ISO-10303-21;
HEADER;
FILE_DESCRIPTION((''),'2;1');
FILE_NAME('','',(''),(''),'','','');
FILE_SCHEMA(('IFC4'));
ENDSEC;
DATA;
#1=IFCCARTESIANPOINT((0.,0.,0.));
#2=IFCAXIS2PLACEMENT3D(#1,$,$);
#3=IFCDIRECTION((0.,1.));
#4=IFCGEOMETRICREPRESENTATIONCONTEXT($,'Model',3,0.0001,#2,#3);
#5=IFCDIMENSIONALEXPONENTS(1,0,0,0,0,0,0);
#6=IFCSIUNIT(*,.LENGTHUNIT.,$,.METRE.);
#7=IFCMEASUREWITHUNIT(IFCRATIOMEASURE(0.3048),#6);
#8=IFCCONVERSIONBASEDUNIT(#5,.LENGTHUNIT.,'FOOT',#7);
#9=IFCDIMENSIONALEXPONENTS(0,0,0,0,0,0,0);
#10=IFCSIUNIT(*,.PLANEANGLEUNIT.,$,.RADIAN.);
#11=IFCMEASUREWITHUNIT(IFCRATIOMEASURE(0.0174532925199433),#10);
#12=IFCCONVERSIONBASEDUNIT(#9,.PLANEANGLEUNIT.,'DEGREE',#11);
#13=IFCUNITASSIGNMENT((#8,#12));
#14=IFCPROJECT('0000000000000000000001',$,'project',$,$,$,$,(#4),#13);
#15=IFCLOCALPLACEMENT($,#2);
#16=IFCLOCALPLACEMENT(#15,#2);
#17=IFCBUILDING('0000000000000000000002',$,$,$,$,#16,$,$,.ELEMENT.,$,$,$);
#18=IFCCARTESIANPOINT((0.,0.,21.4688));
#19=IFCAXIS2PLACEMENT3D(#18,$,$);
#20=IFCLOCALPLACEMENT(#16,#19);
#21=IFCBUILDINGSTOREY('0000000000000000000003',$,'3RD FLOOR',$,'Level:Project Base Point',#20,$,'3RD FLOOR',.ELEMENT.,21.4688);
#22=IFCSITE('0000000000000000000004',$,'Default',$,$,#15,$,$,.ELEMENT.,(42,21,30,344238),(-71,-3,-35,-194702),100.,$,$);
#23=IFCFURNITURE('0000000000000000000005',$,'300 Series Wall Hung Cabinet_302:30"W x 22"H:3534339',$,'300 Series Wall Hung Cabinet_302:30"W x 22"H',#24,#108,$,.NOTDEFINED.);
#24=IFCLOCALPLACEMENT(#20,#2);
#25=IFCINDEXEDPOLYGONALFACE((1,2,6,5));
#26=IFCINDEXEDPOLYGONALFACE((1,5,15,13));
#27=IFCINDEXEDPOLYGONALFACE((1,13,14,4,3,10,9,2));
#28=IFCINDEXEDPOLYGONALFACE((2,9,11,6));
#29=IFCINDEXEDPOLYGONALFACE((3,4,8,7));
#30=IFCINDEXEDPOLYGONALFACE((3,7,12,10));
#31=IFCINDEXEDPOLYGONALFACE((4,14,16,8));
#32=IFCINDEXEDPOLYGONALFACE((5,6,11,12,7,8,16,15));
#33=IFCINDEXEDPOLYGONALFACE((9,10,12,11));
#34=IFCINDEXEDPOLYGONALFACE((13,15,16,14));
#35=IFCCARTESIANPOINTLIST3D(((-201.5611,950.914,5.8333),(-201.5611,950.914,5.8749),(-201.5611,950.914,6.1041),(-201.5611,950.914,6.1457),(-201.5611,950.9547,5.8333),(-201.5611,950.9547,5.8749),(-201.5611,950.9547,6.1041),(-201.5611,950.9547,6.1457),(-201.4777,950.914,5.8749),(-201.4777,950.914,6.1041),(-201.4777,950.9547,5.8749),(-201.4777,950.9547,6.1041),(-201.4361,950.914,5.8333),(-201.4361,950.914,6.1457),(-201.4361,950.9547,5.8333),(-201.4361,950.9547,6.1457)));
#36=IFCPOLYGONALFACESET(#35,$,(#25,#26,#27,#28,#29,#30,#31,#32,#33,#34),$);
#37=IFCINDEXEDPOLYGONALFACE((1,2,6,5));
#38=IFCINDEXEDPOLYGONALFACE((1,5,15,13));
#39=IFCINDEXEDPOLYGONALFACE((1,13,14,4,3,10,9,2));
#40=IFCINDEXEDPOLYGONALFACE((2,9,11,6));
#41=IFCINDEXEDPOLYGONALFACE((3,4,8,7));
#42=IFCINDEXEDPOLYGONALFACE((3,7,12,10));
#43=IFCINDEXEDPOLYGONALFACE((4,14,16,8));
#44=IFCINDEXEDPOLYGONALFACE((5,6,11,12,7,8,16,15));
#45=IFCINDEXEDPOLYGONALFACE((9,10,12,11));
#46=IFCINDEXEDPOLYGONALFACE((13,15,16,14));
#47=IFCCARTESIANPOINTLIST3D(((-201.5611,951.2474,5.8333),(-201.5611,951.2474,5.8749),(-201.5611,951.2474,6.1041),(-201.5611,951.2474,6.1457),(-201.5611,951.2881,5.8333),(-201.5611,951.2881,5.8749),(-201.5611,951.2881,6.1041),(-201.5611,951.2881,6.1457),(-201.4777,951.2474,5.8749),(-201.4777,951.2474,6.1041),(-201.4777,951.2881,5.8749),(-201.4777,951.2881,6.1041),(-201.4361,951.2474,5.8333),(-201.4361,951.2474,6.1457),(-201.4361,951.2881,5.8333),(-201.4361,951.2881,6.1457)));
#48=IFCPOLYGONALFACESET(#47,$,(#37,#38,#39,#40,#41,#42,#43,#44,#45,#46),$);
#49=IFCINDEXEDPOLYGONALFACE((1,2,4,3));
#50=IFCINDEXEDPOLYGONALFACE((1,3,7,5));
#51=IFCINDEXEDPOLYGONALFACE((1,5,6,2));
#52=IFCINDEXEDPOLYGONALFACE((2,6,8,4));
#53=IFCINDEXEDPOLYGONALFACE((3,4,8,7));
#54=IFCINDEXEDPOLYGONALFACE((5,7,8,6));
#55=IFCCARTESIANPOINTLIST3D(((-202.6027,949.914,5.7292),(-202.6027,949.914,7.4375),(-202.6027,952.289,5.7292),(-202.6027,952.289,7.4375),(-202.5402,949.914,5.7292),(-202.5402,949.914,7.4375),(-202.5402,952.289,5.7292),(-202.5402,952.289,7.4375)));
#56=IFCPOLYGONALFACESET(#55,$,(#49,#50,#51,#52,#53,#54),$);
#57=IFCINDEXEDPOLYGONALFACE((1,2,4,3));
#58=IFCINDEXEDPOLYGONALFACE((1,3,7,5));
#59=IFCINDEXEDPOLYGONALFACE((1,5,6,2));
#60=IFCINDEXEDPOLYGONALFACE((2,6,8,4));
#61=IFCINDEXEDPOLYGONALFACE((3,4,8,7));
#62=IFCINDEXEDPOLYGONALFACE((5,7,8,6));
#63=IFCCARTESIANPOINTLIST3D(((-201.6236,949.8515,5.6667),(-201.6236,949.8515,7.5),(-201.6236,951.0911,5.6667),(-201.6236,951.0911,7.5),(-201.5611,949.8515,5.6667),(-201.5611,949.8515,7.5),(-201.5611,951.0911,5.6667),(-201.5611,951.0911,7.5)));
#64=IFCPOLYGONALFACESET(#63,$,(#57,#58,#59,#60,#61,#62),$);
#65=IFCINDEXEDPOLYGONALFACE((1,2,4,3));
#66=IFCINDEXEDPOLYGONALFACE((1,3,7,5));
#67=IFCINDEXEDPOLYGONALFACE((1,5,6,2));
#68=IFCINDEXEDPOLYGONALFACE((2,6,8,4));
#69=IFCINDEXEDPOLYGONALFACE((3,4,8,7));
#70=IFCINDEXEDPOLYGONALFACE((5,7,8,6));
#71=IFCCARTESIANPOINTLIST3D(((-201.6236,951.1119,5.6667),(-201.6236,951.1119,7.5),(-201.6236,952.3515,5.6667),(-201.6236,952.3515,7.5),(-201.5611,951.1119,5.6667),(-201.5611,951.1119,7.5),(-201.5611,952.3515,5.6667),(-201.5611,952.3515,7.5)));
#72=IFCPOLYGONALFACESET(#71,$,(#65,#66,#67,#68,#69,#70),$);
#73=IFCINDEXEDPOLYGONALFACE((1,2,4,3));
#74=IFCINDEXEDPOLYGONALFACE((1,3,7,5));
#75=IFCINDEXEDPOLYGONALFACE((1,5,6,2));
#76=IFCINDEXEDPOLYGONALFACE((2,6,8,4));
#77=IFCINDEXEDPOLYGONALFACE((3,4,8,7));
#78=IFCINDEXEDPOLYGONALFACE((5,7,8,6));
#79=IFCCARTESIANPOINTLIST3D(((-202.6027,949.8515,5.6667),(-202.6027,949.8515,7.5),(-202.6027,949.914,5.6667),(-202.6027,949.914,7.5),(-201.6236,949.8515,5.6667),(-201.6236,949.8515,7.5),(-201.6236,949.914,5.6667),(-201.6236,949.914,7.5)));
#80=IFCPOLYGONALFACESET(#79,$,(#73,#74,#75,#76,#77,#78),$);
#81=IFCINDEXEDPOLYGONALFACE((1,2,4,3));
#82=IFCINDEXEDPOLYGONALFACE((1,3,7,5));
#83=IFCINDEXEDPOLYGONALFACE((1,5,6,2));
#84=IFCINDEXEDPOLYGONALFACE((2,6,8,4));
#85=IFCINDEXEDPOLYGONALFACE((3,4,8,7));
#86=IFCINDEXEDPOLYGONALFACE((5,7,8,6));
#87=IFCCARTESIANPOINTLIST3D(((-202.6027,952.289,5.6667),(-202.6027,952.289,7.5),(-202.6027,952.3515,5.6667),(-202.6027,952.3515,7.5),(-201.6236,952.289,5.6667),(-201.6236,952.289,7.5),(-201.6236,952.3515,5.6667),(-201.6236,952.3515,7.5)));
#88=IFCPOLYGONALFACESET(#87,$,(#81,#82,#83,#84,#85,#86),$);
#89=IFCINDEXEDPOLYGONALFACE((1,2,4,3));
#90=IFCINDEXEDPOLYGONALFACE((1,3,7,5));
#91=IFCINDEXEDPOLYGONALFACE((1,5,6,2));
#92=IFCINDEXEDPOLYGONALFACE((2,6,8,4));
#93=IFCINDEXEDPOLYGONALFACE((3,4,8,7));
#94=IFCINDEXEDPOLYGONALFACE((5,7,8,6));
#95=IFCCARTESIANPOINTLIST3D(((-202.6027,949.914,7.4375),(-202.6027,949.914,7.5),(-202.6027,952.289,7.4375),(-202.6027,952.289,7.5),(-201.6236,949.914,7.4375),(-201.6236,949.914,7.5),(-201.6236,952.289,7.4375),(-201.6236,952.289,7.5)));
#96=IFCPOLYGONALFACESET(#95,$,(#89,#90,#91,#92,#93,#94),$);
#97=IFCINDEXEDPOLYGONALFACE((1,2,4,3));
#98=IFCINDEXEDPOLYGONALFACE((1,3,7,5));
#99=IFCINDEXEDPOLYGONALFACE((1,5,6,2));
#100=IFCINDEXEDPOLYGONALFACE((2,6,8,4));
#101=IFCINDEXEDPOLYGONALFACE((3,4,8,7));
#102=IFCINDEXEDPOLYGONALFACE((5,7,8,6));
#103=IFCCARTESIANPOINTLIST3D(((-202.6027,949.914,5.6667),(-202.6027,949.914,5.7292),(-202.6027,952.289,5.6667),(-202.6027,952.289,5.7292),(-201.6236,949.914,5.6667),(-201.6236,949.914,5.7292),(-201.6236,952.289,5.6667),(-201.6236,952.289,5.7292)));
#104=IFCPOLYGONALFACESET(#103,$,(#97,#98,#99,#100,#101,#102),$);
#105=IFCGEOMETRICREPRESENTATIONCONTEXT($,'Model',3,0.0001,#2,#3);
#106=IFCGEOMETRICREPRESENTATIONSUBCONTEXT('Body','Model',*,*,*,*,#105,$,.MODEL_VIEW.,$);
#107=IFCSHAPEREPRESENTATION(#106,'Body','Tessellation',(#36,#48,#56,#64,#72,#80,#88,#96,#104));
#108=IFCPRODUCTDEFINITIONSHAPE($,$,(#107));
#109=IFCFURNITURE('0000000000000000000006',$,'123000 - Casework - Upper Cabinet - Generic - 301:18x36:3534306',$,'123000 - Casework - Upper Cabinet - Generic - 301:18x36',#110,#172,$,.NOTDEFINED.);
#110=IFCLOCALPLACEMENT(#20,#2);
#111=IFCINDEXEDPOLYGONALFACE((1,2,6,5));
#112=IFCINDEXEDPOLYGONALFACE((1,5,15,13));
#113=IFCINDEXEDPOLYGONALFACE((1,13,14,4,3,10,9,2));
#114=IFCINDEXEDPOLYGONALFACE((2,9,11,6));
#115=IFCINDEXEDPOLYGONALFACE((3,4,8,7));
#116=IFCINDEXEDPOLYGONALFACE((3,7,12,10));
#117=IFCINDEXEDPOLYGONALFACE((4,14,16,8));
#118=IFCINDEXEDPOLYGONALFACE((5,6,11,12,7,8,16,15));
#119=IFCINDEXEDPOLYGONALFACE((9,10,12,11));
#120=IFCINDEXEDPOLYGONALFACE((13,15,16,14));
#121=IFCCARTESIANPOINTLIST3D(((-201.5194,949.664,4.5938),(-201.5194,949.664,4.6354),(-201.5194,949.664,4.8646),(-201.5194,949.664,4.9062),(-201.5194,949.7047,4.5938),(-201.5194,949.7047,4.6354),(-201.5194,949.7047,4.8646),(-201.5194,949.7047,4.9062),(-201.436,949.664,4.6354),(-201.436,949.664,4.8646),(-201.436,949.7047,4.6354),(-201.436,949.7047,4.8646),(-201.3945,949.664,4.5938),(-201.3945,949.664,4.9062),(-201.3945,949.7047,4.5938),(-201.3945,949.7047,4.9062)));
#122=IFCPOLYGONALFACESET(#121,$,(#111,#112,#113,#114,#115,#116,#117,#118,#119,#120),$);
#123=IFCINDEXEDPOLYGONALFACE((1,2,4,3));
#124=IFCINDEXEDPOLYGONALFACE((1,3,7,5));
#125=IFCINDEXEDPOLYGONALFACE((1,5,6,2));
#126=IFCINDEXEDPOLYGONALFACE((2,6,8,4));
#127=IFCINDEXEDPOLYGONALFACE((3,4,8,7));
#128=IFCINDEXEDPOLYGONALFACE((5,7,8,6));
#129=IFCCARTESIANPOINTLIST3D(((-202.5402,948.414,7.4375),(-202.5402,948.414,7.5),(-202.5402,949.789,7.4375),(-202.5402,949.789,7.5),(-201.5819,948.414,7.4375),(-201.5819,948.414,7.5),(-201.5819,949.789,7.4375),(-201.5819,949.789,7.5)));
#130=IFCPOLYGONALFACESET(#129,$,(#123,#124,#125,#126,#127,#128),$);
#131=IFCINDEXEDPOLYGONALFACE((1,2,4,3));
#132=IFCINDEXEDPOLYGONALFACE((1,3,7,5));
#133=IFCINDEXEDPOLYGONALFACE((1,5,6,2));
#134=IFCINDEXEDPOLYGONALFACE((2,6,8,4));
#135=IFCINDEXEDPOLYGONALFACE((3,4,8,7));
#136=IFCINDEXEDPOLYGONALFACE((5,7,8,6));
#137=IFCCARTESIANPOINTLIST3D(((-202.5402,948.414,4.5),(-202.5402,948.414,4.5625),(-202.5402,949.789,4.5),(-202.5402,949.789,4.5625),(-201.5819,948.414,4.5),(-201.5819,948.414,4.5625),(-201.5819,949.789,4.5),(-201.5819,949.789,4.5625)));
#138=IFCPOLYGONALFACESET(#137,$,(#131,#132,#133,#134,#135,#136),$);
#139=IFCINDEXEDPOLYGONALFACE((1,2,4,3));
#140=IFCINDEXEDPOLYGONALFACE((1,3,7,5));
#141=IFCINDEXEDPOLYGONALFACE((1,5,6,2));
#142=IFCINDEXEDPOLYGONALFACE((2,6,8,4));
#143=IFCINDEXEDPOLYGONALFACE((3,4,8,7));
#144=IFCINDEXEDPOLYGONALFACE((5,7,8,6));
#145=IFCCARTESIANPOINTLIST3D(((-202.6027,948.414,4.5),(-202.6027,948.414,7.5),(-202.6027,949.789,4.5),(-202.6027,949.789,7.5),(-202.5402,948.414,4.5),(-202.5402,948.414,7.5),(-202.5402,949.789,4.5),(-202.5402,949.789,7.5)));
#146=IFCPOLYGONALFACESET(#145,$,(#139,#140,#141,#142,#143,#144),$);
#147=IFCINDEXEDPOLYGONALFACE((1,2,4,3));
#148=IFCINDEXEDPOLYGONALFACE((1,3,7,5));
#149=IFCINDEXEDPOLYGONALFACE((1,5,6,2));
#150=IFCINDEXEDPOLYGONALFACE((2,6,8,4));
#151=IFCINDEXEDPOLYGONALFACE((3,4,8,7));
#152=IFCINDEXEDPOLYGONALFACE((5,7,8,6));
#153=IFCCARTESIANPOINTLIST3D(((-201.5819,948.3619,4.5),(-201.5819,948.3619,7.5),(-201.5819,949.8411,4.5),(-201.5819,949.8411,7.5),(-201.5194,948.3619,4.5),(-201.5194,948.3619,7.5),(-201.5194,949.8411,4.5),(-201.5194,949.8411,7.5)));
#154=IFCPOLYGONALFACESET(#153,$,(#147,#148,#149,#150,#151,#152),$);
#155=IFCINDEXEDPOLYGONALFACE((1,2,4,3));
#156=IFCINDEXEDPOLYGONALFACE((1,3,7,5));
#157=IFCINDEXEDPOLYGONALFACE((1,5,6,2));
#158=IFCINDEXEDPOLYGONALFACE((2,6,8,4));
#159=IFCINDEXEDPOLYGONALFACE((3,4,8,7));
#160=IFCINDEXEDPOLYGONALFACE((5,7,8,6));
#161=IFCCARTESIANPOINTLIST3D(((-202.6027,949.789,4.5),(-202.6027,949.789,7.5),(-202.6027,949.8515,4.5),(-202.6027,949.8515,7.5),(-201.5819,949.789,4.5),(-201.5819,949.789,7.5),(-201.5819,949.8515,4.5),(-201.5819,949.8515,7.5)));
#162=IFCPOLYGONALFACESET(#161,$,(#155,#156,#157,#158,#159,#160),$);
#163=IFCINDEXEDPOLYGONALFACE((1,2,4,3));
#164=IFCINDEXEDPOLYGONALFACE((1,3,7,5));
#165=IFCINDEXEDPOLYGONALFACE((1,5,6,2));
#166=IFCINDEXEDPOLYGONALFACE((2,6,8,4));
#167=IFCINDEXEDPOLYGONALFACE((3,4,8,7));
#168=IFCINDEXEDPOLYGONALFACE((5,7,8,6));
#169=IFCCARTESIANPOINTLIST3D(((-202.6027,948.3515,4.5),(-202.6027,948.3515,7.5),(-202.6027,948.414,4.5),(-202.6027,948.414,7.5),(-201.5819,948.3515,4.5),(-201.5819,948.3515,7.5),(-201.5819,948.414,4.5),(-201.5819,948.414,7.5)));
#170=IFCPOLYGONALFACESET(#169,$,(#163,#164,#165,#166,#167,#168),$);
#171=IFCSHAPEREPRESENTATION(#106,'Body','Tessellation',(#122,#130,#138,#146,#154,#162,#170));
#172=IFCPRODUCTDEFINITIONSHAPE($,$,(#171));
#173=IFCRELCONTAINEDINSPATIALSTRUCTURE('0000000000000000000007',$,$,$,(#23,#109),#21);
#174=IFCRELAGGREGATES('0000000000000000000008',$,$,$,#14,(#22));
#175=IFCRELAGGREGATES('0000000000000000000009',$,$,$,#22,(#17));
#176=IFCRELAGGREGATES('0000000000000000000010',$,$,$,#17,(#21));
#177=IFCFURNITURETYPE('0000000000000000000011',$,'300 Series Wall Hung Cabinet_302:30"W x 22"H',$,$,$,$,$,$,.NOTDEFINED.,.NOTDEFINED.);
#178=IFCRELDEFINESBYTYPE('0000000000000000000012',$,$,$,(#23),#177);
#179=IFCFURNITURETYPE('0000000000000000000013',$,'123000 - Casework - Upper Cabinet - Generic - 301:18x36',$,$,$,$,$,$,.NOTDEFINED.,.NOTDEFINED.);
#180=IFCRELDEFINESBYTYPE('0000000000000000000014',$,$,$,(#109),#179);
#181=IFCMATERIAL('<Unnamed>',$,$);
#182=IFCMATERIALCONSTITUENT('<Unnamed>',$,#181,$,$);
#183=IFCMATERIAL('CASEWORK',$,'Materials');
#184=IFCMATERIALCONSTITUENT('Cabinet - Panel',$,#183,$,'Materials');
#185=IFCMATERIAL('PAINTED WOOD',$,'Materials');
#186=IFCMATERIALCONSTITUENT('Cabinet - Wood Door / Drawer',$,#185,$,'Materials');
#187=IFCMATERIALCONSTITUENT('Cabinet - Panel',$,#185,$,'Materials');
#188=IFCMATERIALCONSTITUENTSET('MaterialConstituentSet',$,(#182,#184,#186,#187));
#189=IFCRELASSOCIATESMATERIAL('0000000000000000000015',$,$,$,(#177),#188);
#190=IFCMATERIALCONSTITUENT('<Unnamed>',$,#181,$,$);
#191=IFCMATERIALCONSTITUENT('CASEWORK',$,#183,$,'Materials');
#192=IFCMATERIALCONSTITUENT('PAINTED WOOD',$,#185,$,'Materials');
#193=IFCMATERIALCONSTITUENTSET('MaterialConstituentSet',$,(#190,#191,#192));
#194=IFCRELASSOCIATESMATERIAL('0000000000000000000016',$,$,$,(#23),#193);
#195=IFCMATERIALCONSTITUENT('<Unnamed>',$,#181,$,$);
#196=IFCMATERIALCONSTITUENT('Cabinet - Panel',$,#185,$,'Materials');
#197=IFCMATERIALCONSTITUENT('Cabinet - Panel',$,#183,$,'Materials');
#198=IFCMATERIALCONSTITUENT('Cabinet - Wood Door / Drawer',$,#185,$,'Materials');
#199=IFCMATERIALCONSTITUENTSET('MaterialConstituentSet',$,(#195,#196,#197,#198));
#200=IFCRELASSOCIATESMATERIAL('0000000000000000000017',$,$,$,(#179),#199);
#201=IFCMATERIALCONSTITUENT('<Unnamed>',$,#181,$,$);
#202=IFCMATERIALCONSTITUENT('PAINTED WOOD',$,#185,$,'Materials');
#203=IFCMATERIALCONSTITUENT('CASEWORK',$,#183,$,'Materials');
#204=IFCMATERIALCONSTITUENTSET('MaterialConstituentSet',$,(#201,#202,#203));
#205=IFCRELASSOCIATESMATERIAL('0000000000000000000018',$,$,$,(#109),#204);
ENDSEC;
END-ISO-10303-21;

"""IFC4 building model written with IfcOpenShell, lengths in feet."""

from ifc_helpers import new_model, entity, si_unit, converted_unit, direction, frame, frame_2d, origin, origin_2d_with_axis, place, context, subcontext, project, spatial, polyline, rectangle, outline, extrude, source, transform, mapped, material, constituent, constituent_set, type_object, type_shapes, element, save


model = new_model("IFC4")

# Units and contexts
model_context_1 = context("Model", 3, precision=0.0001, world=origin(), true_north=direction((0.0, 1.0)))
model_context_2 = context("Model", 3, precision=0.0001, world=origin(), true_north=direction((0.0, 1.0)))
body_context = subcontext(model_context_2, "Body", "Model", "MODEL_VIEW")
ifc_project = project(units=[converted_unit("LENGTHUNIT", "FOOT", entity("IfcRatioMeasure", 0.3048), si_unit("LENGTHUNIT", "METRE"), dimensions=[1, 0, 0, 0, 0, 0, 0]), converted_unit("PLANEANGLEUNIT", "DEGREE", entity("IfcRatioMeasure", 0.0174532925199433), si_unit("PLANEANGLEUNIT", "RADIAN"), dimensions=[0, 0, 0, 0, 0, 0, 0])], contexts=[model_context_1])

# Site, building, storey
site_placement = place(None, origin())
site = spatial("IfcSite", under=ifc_project, at=site_placement, Name="Default", CompositionType="ELEMENT", RefLatitude=(42, 21, 30, 344238), RefLongitude=(-71, -3, -35, -194702), RefElevation=100.0)
building_placement = place(site_placement, origin())
building = spatial("IfcBuilding", under=site, at=building_placement, CompositionType="ELEMENT")
storey_placement = place(building_placement, frame((0.0, 0.0, 21.4688)))
storey = spatial("IfcBuildingStorey", under=building, at=storey_placement, Name="3RD FLOOR", ObjectType="Level:Project Base Point", LongName="3RD FLOOR", CompositionType="ELEMENT", Elevation=21.4688)

# Furniture
ifc_material_1 = material(Name="CASEWORK", Category="Materials")
ifc_material_2 = material(Name="PAINTED WOOD", Category="Materials")
ifc_material_3 = material(Name="<Unnamed>")
ifc_constituent_1 = constituent(ifc_material_3, Name="<Unnamed>")
ifc_constituent_2 = constituent(ifc_material_1, Name="CASEWORK", Category="Materials")
ifc_constituent_3 = constituent(ifc_material_2, Name="PAINTED WOOD", Category="Materials")
ifc_constituent_set_1 = constituent_set(constituents=[ifc_constituent_1, ifc_constituent_2, ifc_constituent_3], Name="MaterialConstituentSet")
ifc_constituent_4 = constituent(ifc_material_3, Name="<Unnamed>")
ifc_constituent_5 = constituent(ifc_material_1, Name="Cabinet - Panel", Category="Materials")
ifc_constituent_6 = constituent(ifc_material_2, Name="Cabinet - Wood Door / Drawer", Category="Materials")
ifc_constituent_7 = constituent(ifc_material_2, Name="Cabinet - Panel", Category="Materials")
ifc_constituent_set_2 = constituent_set(constituents=[ifc_constituent_4, ifc_constituent_5, ifc_constituent_6, ifc_constituent_7], Name="MaterialConstituentSet")
furniture_type_1 = type_object("IfcFurnitureType", Name="300 Series Wall Hung Cabinet_302:30\"W x 22\"H", AssemblyPlace="NOTDEFINED", PredefinedType="NOTDEFINED", material=ifc_constituent_set_2)
shared_shape_1 = source(origin(), body_context, "Body", "SweptSolid", [
    extrude(outline(polyline([(0.1146, -0.0521), (0.1562, -0.0521), (0.1562, 0.0729), (-0.1562, 0.0729), (-0.1562, -0.0521), (-0.1146, -0.0521), (-0.1146, 0.0313), (0.1146, 0.0313), (0.1146, -0.0521)])), frame((1.0625, 0.0729, 0.3229), z_axis=(1.0, 0.0, 0.0), x_axis=(0.0, 0.0, 1.0)), (0.0, 0.0, 1.0), 0.0407),
    extrude(outline(polyline([(0.1146, -0.0521), (0.1562, -0.0521), (0.1562, 0.0729), (-0.1562, 0.0729), (-0.1562, -0.0521), (-0.1146, -0.0521), (-0.1146, 0.0313), (0.1146, 0.0313), (0.1146, -0.0521)])), frame((1.3958, 0.0729, 0.3229), z_axis=(1.0, 0.0, 0.0), x_axis=(0.0, 0.0, 1.0)), (0.0, 0.0, 1.0), 0.0407),
    extrude(rectangle(XDim=2.375, YDim=0.0625, at=origin_2d_with_axis()), frame((1.25, 1.1354, 0.0625), z_axis=(0.0, 0.0, 1.0), x_axis=(-1.0, 0.0, 0.0)), (0.0, 0.0, 1.0), 1.7083),
    extrude(rectangle(XDim=1.2396, YDim=0.0625, at=origin_2d_with_axis()), frame((0.6198, 0.1562, 0.0), z_axis=(0.0, 0.0, 1.0), x_axis=(-1.0, 0.0, 0.0)), (0.0, 0.0, 1.0), 1.8333),
    extrude(rectangle(XDim=1.2396, YDim=0.0625, at=frame_2d((0.0, 0.0), x_axis=(1.0, 0.0))), frame((1.8802, 0.1562, 0.0), z_axis=(0.0, 0.0, 1.0), x_axis=(-1.0, 0.0, 0.0)), (0.0, 0.0, 1.0), 1.8333),
    extrude(rectangle(XDim=0.9792, YDim=0.0625, at=frame_2d((0.0, 0.0), x_axis=(1.0, 0.0))), frame((0.0313, 0.677, 0.0), z_axis=(0.0, 0.0, 1.0), x_axis=(0.0, -1.0, 0.0)), (0.0, 0.0, 1.0), 1.8333),
    extrude(rectangle(XDim=0.9792, YDim=0.0625, at=frame_2d((0.0, 0.0), x_axis=(1.0, 0.0))), frame((2.4688, 0.677, 0.0), z_axis=(0.0, 0.0, 1.0), x_axis=(0.0, -1.0, 0.0)), (0.0, 0.0, 1.0), 1.8333),
    extrude(rectangle(XDim=0.9792, YDim=2.375, at=frame_2d((0.0, 0.0), x_axis=(1.0, 0.0))), frame((1.25, 0.677, 1.7708), z_axis=(0.0, 0.0, 1.0), x_axis=(0.0, 1.0, 0.0)), (0.0, 0.0, 1.0), 0.0625),
    extrude(rectangle(XDim=0.9792, YDim=2.375, at=frame_2d((0.0, 0.0), x_axis=(1.0, 0.0))), frame((1.25, 0.677, 0.0), z_axis=(0.0, 0.0, 1.0), x_axis=(0.0, 1.0, 0.0)), (0.0, 0.0, 1.0), 0.0625),
])
type_shapes(furniture_type_1, [shared_shape_1])
furniture_1_placement = place(storey_placement, frame((-201.4361, 949.8515, 5.6667), z_axis=(0.0, 0.0, 1.0), x_axis=(0.0, 1.0, 0.0)))
element("IfcFurniture", 1, at=furniture_1_placement, inside=storey, type_object=furniture_type_1, material=ifc_constituent_set_1, Name="300 Series Wall Hung Cabinet_302:30\"W x 22\"H:3534339", ObjectType="300 Series Wall Hung Cabinet_302:30\"W x 22\"H", PredefinedType="NOTDEFINED", context=body_context, shape_type="MappedRepresentation", body=[
    mapped(shared_shape_1, transform((0.0, 0.0, 0.0), scale=1.0)),
])
ifc_constituent_8 = constituent(ifc_material_3, Name="<Unnamed>")
ifc_constituent_9 = constituent(ifc_material_2, Name="PAINTED WOOD", Category="Materials")
ifc_constituent_10 = constituent(ifc_material_1, Name="CASEWORK", Category="Materials")
ifc_constituent_set_3 = constituent_set(constituents=[ifc_constituent_8, ifc_constituent_9, ifc_constituent_10], Name="MaterialConstituentSet")
ifc_constituent_11 = constituent(ifc_material_3, Name="<Unnamed>")
ifc_constituent_12 = constituent(ifc_material_2, Name="Cabinet - Panel", Category="Materials")
ifc_constituent_13 = constituent(ifc_material_1, Name="Cabinet - Panel", Category="Materials")
ifc_constituent_14 = constituent(ifc_material_2, Name="Cabinet - Wood Door / Drawer", Category="Materials")
ifc_constituent_set_4 = constituent_set(constituents=[ifc_constituent_11, ifc_constituent_12, ifc_constituent_13, ifc_constituent_14], Name="MaterialConstituentSet")
furniture_type_2 = type_object("IfcFurnitureType", Name="123000 - Casework - Upper Cabinet - Generic - 301:18x36", AssemblyPlace="NOTDEFINED", PredefinedType="NOTDEFINED", material=ifc_constituent_set_4)
shared_shape_2 = source(origin(), body_context, "Body", "SweptSolid", [
    extrude(outline(polyline([(-0.0521, -0.1146), (-0.0521, -0.1562), (0.0729, -0.1562), (0.0729, 0.1562), (-0.0521, 0.1562), (-0.0521, 0.1146), (0.0313, 0.1146), (0.0313, -0.1146), (-0.0521, -0.1146)])), frame((0.1468, 1.1354, 0.25), z_axis=(-1.0, 0.0, 0.0), x_axis=(0.0, 1.0, 0.0)), (0.0, 0.0, -1.0), 0.0407),
    extrude(rectangle(XDim=0.9583, YDim=1.375, at=frame_2d((0.0, 0.0), x_axis=(1.0, 0.0))), frame((0.75, 0.5417, 2.9375), z_axis=(0.0, 0.0, 1.0), x_axis=(0.0, 1.0, 0.0)), (0.0, 0.0, 1.0), 0.0625),
    extrude(rectangle(XDim=0.9583, YDim=1.375, at=frame_2d((0.0, 0.0), x_axis=(1.0, 0.0))), frame((0.75, 0.5417, 0.0), z_axis=(0.0, 0.0, 1.0), x_axis=(0.0, 1.0, 0.0)), (0.0, 0.0, 1.0), 0.0625),
    extrude(rectangle(XDim=1.375, YDim=0.0625, at=origin_2d_with_axis()), frame((0.75, 0.0313, 0.0), z_axis=(0.0, 0.0, 1.0), x_axis=(-1.0, 0.0, 0.0)), (0.0, 0.0, 1.0), 3.0),
    extrude(rectangle(XDim=1.4792, YDim=0.0625, at=origin_2d_with_axis()), frame((0.75, 1.0521, 0.0)), (0.0, 0.0, 1.0), 3.0),
    extrude(rectangle(XDim=1.0208, YDim=0.0625, at=origin_2d_with_axis()), frame((0.0312, 0.5104, 0.0), z_axis=(0.0, 0.0, 1.0), x_axis=(0.0, 1.0, 0.0)), (0.0, 0.0, 1.0), 3.0),
    extrude(rectangle(XDim=1.0208, YDim=0.0625, at=origin_2d_with_axis()), frame((1.4688, 0.5104, 0.0), z_axis=(0.0, 0.0, 1.0), x_axis=(0.0, 1.0, 0.0)), (0.0, 0.0, 1.0), 3.0),
])
type_shapes(furniture_type_2, [shared_shape_2])
furniture_2_placement = place(storey_placement, frame((-202.6027, 949.8515, 4.5), z_axis=(0.0, 0.0, 1.0), x_axis=(0.0, -1.0, 0.0)))
element("IfcFurniture", 2, at=furniture_2_placement, inside=storey, type_object=furniture_type_2, material=ifc_constituent_set_3, Name="123000 - Casework - Upper Cabinet - Generic - 301:18x36:3534306", ObjectType="123000 - Casework - Upper Cabinet - Generic - 301:18x36", PredefinedType="NOTDEFINED", context=body_context, shape_type="MappedRepresentation", body=[
    mapped(shared_shape_2, transform((0.0, 0.0, 0.0), scale=1.0)),
])

save(model, "model.ifc")
